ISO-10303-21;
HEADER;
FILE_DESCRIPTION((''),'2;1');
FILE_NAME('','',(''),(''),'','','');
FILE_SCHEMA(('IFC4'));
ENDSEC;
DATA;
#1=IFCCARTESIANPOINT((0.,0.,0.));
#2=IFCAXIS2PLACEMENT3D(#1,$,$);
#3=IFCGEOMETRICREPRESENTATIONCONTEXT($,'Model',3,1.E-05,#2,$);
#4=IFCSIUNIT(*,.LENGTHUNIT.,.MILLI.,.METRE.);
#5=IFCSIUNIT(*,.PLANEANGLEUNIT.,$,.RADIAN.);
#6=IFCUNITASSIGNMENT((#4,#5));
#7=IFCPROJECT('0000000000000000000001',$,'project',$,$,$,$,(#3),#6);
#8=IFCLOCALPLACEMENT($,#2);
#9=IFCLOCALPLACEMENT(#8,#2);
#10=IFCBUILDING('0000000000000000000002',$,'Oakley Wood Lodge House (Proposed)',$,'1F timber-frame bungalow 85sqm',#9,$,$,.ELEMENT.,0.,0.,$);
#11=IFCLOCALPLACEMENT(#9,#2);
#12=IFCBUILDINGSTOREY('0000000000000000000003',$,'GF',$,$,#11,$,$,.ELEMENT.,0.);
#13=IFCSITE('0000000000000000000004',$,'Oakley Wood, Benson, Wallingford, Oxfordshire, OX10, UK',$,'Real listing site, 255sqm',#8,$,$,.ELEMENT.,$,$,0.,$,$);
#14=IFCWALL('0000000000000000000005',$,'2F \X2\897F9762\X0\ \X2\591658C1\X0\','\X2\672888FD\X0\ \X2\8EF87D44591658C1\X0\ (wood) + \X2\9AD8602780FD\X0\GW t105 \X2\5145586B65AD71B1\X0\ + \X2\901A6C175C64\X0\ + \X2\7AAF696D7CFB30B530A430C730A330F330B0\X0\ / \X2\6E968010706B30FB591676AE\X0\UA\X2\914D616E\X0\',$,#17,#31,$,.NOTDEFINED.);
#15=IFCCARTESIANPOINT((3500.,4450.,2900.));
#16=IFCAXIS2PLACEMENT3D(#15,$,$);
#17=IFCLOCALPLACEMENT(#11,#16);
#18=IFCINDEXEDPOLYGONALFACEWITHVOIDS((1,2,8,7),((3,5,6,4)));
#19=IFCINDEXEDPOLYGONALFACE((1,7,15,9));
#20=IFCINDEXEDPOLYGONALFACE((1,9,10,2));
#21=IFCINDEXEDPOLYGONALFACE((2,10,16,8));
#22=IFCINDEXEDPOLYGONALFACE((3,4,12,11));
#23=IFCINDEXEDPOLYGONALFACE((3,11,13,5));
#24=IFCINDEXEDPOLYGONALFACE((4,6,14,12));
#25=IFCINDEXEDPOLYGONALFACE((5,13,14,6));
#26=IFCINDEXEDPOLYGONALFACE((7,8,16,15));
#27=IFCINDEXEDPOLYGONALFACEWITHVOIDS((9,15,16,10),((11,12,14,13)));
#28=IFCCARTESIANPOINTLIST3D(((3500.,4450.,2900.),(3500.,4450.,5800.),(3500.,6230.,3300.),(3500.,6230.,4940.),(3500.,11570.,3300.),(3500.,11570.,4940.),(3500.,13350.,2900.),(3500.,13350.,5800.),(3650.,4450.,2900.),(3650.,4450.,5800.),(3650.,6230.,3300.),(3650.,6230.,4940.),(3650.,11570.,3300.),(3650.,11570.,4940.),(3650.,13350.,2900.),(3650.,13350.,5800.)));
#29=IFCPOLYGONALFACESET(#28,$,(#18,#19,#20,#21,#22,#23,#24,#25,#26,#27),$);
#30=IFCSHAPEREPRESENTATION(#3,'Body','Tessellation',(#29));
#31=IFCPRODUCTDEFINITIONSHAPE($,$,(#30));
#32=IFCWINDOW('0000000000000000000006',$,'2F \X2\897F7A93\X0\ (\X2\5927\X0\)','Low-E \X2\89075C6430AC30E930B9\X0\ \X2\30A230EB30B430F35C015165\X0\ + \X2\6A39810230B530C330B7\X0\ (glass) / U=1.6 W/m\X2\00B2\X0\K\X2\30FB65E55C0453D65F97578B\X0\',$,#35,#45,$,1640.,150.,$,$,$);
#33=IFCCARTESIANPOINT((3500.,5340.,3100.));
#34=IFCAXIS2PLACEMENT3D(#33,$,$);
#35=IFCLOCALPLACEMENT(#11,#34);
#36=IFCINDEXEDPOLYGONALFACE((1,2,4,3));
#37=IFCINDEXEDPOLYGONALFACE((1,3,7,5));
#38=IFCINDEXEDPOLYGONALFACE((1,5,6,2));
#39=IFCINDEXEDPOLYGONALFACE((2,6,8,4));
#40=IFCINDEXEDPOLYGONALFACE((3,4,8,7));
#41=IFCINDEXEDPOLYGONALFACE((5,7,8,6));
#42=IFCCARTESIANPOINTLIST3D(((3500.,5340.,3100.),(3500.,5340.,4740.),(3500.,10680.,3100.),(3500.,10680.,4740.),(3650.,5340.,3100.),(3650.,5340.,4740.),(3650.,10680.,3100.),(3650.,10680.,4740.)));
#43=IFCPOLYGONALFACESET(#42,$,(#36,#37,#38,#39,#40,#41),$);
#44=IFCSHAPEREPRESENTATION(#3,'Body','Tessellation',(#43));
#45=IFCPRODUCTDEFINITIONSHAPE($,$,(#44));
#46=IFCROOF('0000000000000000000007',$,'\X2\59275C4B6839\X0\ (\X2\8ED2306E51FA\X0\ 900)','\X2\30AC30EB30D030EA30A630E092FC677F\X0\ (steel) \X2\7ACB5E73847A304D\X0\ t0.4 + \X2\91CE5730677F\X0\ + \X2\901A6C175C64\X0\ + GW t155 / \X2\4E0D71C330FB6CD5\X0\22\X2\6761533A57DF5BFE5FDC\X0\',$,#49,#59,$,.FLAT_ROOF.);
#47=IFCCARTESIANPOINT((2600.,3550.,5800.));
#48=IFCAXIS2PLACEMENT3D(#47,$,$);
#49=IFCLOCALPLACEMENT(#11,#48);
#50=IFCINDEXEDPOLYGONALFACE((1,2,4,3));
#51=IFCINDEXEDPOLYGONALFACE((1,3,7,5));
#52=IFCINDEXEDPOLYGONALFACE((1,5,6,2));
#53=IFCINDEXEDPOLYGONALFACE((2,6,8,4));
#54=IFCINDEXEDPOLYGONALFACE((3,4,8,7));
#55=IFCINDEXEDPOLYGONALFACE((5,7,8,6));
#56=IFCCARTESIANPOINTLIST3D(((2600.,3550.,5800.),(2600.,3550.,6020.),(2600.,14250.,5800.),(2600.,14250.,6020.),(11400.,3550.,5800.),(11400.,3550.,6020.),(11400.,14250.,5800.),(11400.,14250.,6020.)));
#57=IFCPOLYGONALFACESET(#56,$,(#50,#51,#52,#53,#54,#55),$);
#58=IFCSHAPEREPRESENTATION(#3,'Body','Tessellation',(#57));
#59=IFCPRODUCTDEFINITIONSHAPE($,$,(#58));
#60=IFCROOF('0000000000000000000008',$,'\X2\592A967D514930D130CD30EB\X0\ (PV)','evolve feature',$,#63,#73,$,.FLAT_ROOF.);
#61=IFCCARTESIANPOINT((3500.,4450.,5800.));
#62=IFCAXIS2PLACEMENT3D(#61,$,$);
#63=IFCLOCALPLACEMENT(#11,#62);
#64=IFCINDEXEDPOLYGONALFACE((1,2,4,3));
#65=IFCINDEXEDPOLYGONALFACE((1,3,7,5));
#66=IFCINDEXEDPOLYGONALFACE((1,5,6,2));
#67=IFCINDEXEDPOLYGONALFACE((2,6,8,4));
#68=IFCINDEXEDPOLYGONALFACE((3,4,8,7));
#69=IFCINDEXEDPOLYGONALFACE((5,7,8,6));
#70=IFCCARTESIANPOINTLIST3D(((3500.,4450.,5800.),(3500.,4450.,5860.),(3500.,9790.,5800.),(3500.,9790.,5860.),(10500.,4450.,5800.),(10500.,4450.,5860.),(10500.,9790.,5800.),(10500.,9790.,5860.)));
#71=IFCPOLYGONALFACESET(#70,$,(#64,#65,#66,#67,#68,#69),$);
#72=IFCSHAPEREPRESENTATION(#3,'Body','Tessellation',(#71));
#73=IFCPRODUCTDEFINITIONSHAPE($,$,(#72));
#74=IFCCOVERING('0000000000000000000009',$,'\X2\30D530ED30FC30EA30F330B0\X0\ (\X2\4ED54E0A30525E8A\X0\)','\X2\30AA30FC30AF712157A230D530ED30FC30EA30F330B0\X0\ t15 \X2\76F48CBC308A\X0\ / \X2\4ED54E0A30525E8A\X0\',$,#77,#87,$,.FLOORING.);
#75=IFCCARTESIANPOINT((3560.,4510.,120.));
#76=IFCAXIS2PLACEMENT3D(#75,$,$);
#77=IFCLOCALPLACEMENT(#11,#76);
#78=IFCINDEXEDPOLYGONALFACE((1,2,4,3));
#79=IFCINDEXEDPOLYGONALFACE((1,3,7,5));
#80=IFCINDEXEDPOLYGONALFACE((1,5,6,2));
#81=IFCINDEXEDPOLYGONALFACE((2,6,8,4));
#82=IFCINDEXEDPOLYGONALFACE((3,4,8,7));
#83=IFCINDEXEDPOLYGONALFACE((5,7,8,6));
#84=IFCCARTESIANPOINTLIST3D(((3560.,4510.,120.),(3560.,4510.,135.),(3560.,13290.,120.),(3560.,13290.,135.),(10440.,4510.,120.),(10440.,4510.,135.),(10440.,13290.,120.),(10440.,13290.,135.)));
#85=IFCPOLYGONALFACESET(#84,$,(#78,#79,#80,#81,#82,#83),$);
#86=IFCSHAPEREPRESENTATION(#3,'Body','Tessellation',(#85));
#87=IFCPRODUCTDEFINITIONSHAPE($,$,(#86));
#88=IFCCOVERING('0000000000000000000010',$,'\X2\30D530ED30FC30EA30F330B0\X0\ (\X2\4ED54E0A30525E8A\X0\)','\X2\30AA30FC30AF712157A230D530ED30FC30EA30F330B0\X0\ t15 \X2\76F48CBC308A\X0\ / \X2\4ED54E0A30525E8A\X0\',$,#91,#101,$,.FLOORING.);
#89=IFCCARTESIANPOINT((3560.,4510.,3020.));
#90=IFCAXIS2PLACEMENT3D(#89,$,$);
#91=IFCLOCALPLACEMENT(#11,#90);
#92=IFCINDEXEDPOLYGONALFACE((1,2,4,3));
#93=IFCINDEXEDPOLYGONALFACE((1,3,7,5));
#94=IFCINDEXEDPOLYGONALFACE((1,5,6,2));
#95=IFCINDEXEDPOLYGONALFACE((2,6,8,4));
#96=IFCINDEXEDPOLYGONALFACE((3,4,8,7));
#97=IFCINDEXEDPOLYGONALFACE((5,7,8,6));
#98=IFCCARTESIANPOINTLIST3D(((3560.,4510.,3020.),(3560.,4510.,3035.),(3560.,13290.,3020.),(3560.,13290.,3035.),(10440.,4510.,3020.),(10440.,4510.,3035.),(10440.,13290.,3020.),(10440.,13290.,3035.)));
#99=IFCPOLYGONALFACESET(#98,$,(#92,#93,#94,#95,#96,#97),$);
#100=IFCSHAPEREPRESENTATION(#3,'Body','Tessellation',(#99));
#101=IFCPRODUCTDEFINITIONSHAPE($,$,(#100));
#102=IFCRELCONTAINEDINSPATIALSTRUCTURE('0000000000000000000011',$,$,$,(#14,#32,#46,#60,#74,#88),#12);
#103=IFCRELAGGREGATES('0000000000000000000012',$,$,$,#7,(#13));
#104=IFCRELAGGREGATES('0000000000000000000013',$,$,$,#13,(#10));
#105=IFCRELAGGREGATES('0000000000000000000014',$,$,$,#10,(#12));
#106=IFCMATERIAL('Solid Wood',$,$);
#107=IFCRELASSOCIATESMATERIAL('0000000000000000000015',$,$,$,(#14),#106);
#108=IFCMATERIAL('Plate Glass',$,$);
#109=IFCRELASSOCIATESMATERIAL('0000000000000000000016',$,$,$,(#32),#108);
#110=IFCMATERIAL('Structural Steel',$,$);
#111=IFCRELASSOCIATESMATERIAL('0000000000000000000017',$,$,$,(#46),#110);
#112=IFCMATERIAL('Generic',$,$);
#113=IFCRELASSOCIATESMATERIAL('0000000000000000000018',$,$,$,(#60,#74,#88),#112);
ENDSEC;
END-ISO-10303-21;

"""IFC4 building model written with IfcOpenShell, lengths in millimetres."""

from ifc_helpers import new_model, si_unit, frame, frame_2d, origin, place, context, project, spatial, rectangle, extrude, material, element, fill, save


model = new_model("IFC4")

# Units and contexts
model_context = context("Model", 3, precision=1e-05, world=origin())
ifc_project = project(units=[si_unit("LENGTHUNIT", "METRE", prefix="MILLI"), si_unit("PLANEANGLEUNIT", "RADIAN")], contexts=[model_context])

# Site, building, storey
site_placement = place(None, origin())
site = spatial("IfcSite", under=ifc_project, at=site_placement, Name="Oakley Wood, Benson, Wallingford, Oxfordshire, OX10, UK", ObjectType="Real listing site, 255sqm", CompositionType="ELEMENT", RefElevation=0.0)
building_placement = place(site_placement, origin())
building = spatial("IfcBuilding", under=site, at=building_placement, Name="Oakley Wood Lodge House (Proposed)", ObjectType="1F timber-frame bungalow 85sqm", CompositionType="ELEMENT", ElevationOfRefHeight=0.0, ElevationOfTerrain=0.0)
storey_placement = place(building_placement, origin())
storey = spatial("IfcBuildingStorey", under=building, at=storey_placement, Name="GF", CompositionType="ELEMENT", Elevation=0.0)

# Shared definitions
ifc_material_1 = material(Name="Solid Wood")
ifc_material_2 = material(Name="Generic")

# Shared definitions
ifc_material_3 = material(Name="Plate Glass")

# Wall, opening, window
wall_1_placement = place(storey_placement, frame((3500.0, 4450.0, 2900.0)))
wall_1 = element("IfcWall", 1, at=wall_1_placement, inside=storey, material=ifc_material_1, Name="2F 西面 外壁", Description="木製 軸組外壁 (wood) + 高性能GW t105 充填断熱 + 通気層 + 窯業系サイディング / 準耐火・外皮UA配慮", PredefinedType="NOTDEFINED", context=model_context, shape_type="SweptSolid", body=[
    extrude(rectangle(XDim=150.0, YDim=8900.0, at=frame_2d((75.0, 4450.0))), frame((3500.0, 4450.0, 2900.0)), (0.0, 0.0, 1.0), 2900.0),
])
opening_1_placement = place(storey_placement, frame((3500.0, 5340.0, 3100.0)))
opening_1 = element("IfcOpeningElement", 2, at=opening_1_placement, cuts=wall_1, PredefinedType="NOTDEFINED", context=model_context, shape_type="SweptSolid", body=[
    extrude(rectangle(XDim=150.0, YDim=5340.0, at=frame_2d((75.0, 2670.0))), frame((3500.0, 5340.0, 3100.0)), (0.0, 0.0, 1.0), 1640.0),
])
window_1_placement = place(storey_placement, frame((3500.0, 5340.0, 3100.0)))
window_1 = element("IfcWindow", 3, at=window_1_placement, inside=storey, material=ifc_material_3, Name="2F 西窓 (大)", Description="Low-E 複層ガラス アルゴン封入 + 樹脂サッシ (glass) / U=1.6 W/m²K・日射取得型", OverallHeight=1640.0, OverallWidth=150.0, context=model_context, shape_type="SweptSolid", body=[
    extrude(rectangle(XDim=150.0, YDim=5340.0, at=frame_2d((75.0, 2670.0))), frame((3500.0, 5340.0, 3100.0)), (0.0, 0.0, 1.0), 1640.0),
])
fill(opening_1, window_1)

# Roofs
ifc_material_4 = material(Name="Structural Steel")
roof_1_placement = place(storey_placement, frame((2600.0, 3550.0, 5800.0)))
element("IfcRoof", 4, at=roof_1_placement, inside=storey, material=ifc_material_4, Name="大屋根 (軒の出 900)", Description="ガルバリウム鋼板 (steel) 立平葺き t0.4 + 野地板 + 通気層 + GW t155 / 不燃・法22条区域対応", PredefinedType="FLAT_ROOF", context=model_context, shape_type="SweptSolid", body=[
    extrude(rectangle(XDim=8800.0, YDim=10700.0, at=frame_2d((4400.0, 5350.0))), frame((2600.0, 3550.0, 5800.0)), (0.0, 0.0, 1.0), 220.0),
])
roof_2_placement = place(storey_placement, frame((3500.0, 4450.0, 5800.0)))
element("IfcRoof", 5, at=roof_2_placement, inside=storey, material=ifc_material_2, Name="太陽光パネル (PV)", Description="evolve feature", PredefinedType="FLAT_ROOF", context=model_context, shape_type="SweptSolid", body=[
    extrude(rectangle(XDim=7000.0, YDim=5340.0, at=frame_2d((3500.0, 2670.0))), frame((3500.0, 4450.0, 5800.0)), (0.0, 0.0, 1.0), 60.0),
])

# Coverings
covering_1_placement = place(storey_placement, frame((3560.0, 4510.0, 120.0)))
element("IfcCovering", 6, at=covering_1_placement, inside=storey, material=ifc_material_2, Name="フローリング (仕上げ床)", Description="オーク無垢フローリング t15 直貼り / 仕上げ床", PredefinedType="FLOORING", context=model_context, shape_type="SweptSolid", body=[
    extrude(rectangle(XDim=6880.0, YDim=8780.0, at=frame_2d((3440.0, 4390.0))), frame((3560.0, 4510.0, 120.0)), (0.0, 0.0, 1.0), 15.0),
])
covering_2_placement = place(storey_placement, frame((3560.0, 4510.0, 3020.0)))
element("IfcCovering", 7, at=covering_2_placement, inside=storey, material=ifc_material_2, Name="フローリング (仕上げ床)", Description="オーク無垢フローリング t15 直貼り / 仕上げ床", PredefinedType="FLOORING", context=model_context, shape_type="SweptSolid", body=[
    extrude(rectangle(XDim=6880.0, YDim=8780.0, at=frame_2d((3440.0, 4390.0))), frame((3560.0, 4510.0, 3020.0)), (0.0, 0.0, 1.0), 15.0),
])

save(model, "model.ifc")
